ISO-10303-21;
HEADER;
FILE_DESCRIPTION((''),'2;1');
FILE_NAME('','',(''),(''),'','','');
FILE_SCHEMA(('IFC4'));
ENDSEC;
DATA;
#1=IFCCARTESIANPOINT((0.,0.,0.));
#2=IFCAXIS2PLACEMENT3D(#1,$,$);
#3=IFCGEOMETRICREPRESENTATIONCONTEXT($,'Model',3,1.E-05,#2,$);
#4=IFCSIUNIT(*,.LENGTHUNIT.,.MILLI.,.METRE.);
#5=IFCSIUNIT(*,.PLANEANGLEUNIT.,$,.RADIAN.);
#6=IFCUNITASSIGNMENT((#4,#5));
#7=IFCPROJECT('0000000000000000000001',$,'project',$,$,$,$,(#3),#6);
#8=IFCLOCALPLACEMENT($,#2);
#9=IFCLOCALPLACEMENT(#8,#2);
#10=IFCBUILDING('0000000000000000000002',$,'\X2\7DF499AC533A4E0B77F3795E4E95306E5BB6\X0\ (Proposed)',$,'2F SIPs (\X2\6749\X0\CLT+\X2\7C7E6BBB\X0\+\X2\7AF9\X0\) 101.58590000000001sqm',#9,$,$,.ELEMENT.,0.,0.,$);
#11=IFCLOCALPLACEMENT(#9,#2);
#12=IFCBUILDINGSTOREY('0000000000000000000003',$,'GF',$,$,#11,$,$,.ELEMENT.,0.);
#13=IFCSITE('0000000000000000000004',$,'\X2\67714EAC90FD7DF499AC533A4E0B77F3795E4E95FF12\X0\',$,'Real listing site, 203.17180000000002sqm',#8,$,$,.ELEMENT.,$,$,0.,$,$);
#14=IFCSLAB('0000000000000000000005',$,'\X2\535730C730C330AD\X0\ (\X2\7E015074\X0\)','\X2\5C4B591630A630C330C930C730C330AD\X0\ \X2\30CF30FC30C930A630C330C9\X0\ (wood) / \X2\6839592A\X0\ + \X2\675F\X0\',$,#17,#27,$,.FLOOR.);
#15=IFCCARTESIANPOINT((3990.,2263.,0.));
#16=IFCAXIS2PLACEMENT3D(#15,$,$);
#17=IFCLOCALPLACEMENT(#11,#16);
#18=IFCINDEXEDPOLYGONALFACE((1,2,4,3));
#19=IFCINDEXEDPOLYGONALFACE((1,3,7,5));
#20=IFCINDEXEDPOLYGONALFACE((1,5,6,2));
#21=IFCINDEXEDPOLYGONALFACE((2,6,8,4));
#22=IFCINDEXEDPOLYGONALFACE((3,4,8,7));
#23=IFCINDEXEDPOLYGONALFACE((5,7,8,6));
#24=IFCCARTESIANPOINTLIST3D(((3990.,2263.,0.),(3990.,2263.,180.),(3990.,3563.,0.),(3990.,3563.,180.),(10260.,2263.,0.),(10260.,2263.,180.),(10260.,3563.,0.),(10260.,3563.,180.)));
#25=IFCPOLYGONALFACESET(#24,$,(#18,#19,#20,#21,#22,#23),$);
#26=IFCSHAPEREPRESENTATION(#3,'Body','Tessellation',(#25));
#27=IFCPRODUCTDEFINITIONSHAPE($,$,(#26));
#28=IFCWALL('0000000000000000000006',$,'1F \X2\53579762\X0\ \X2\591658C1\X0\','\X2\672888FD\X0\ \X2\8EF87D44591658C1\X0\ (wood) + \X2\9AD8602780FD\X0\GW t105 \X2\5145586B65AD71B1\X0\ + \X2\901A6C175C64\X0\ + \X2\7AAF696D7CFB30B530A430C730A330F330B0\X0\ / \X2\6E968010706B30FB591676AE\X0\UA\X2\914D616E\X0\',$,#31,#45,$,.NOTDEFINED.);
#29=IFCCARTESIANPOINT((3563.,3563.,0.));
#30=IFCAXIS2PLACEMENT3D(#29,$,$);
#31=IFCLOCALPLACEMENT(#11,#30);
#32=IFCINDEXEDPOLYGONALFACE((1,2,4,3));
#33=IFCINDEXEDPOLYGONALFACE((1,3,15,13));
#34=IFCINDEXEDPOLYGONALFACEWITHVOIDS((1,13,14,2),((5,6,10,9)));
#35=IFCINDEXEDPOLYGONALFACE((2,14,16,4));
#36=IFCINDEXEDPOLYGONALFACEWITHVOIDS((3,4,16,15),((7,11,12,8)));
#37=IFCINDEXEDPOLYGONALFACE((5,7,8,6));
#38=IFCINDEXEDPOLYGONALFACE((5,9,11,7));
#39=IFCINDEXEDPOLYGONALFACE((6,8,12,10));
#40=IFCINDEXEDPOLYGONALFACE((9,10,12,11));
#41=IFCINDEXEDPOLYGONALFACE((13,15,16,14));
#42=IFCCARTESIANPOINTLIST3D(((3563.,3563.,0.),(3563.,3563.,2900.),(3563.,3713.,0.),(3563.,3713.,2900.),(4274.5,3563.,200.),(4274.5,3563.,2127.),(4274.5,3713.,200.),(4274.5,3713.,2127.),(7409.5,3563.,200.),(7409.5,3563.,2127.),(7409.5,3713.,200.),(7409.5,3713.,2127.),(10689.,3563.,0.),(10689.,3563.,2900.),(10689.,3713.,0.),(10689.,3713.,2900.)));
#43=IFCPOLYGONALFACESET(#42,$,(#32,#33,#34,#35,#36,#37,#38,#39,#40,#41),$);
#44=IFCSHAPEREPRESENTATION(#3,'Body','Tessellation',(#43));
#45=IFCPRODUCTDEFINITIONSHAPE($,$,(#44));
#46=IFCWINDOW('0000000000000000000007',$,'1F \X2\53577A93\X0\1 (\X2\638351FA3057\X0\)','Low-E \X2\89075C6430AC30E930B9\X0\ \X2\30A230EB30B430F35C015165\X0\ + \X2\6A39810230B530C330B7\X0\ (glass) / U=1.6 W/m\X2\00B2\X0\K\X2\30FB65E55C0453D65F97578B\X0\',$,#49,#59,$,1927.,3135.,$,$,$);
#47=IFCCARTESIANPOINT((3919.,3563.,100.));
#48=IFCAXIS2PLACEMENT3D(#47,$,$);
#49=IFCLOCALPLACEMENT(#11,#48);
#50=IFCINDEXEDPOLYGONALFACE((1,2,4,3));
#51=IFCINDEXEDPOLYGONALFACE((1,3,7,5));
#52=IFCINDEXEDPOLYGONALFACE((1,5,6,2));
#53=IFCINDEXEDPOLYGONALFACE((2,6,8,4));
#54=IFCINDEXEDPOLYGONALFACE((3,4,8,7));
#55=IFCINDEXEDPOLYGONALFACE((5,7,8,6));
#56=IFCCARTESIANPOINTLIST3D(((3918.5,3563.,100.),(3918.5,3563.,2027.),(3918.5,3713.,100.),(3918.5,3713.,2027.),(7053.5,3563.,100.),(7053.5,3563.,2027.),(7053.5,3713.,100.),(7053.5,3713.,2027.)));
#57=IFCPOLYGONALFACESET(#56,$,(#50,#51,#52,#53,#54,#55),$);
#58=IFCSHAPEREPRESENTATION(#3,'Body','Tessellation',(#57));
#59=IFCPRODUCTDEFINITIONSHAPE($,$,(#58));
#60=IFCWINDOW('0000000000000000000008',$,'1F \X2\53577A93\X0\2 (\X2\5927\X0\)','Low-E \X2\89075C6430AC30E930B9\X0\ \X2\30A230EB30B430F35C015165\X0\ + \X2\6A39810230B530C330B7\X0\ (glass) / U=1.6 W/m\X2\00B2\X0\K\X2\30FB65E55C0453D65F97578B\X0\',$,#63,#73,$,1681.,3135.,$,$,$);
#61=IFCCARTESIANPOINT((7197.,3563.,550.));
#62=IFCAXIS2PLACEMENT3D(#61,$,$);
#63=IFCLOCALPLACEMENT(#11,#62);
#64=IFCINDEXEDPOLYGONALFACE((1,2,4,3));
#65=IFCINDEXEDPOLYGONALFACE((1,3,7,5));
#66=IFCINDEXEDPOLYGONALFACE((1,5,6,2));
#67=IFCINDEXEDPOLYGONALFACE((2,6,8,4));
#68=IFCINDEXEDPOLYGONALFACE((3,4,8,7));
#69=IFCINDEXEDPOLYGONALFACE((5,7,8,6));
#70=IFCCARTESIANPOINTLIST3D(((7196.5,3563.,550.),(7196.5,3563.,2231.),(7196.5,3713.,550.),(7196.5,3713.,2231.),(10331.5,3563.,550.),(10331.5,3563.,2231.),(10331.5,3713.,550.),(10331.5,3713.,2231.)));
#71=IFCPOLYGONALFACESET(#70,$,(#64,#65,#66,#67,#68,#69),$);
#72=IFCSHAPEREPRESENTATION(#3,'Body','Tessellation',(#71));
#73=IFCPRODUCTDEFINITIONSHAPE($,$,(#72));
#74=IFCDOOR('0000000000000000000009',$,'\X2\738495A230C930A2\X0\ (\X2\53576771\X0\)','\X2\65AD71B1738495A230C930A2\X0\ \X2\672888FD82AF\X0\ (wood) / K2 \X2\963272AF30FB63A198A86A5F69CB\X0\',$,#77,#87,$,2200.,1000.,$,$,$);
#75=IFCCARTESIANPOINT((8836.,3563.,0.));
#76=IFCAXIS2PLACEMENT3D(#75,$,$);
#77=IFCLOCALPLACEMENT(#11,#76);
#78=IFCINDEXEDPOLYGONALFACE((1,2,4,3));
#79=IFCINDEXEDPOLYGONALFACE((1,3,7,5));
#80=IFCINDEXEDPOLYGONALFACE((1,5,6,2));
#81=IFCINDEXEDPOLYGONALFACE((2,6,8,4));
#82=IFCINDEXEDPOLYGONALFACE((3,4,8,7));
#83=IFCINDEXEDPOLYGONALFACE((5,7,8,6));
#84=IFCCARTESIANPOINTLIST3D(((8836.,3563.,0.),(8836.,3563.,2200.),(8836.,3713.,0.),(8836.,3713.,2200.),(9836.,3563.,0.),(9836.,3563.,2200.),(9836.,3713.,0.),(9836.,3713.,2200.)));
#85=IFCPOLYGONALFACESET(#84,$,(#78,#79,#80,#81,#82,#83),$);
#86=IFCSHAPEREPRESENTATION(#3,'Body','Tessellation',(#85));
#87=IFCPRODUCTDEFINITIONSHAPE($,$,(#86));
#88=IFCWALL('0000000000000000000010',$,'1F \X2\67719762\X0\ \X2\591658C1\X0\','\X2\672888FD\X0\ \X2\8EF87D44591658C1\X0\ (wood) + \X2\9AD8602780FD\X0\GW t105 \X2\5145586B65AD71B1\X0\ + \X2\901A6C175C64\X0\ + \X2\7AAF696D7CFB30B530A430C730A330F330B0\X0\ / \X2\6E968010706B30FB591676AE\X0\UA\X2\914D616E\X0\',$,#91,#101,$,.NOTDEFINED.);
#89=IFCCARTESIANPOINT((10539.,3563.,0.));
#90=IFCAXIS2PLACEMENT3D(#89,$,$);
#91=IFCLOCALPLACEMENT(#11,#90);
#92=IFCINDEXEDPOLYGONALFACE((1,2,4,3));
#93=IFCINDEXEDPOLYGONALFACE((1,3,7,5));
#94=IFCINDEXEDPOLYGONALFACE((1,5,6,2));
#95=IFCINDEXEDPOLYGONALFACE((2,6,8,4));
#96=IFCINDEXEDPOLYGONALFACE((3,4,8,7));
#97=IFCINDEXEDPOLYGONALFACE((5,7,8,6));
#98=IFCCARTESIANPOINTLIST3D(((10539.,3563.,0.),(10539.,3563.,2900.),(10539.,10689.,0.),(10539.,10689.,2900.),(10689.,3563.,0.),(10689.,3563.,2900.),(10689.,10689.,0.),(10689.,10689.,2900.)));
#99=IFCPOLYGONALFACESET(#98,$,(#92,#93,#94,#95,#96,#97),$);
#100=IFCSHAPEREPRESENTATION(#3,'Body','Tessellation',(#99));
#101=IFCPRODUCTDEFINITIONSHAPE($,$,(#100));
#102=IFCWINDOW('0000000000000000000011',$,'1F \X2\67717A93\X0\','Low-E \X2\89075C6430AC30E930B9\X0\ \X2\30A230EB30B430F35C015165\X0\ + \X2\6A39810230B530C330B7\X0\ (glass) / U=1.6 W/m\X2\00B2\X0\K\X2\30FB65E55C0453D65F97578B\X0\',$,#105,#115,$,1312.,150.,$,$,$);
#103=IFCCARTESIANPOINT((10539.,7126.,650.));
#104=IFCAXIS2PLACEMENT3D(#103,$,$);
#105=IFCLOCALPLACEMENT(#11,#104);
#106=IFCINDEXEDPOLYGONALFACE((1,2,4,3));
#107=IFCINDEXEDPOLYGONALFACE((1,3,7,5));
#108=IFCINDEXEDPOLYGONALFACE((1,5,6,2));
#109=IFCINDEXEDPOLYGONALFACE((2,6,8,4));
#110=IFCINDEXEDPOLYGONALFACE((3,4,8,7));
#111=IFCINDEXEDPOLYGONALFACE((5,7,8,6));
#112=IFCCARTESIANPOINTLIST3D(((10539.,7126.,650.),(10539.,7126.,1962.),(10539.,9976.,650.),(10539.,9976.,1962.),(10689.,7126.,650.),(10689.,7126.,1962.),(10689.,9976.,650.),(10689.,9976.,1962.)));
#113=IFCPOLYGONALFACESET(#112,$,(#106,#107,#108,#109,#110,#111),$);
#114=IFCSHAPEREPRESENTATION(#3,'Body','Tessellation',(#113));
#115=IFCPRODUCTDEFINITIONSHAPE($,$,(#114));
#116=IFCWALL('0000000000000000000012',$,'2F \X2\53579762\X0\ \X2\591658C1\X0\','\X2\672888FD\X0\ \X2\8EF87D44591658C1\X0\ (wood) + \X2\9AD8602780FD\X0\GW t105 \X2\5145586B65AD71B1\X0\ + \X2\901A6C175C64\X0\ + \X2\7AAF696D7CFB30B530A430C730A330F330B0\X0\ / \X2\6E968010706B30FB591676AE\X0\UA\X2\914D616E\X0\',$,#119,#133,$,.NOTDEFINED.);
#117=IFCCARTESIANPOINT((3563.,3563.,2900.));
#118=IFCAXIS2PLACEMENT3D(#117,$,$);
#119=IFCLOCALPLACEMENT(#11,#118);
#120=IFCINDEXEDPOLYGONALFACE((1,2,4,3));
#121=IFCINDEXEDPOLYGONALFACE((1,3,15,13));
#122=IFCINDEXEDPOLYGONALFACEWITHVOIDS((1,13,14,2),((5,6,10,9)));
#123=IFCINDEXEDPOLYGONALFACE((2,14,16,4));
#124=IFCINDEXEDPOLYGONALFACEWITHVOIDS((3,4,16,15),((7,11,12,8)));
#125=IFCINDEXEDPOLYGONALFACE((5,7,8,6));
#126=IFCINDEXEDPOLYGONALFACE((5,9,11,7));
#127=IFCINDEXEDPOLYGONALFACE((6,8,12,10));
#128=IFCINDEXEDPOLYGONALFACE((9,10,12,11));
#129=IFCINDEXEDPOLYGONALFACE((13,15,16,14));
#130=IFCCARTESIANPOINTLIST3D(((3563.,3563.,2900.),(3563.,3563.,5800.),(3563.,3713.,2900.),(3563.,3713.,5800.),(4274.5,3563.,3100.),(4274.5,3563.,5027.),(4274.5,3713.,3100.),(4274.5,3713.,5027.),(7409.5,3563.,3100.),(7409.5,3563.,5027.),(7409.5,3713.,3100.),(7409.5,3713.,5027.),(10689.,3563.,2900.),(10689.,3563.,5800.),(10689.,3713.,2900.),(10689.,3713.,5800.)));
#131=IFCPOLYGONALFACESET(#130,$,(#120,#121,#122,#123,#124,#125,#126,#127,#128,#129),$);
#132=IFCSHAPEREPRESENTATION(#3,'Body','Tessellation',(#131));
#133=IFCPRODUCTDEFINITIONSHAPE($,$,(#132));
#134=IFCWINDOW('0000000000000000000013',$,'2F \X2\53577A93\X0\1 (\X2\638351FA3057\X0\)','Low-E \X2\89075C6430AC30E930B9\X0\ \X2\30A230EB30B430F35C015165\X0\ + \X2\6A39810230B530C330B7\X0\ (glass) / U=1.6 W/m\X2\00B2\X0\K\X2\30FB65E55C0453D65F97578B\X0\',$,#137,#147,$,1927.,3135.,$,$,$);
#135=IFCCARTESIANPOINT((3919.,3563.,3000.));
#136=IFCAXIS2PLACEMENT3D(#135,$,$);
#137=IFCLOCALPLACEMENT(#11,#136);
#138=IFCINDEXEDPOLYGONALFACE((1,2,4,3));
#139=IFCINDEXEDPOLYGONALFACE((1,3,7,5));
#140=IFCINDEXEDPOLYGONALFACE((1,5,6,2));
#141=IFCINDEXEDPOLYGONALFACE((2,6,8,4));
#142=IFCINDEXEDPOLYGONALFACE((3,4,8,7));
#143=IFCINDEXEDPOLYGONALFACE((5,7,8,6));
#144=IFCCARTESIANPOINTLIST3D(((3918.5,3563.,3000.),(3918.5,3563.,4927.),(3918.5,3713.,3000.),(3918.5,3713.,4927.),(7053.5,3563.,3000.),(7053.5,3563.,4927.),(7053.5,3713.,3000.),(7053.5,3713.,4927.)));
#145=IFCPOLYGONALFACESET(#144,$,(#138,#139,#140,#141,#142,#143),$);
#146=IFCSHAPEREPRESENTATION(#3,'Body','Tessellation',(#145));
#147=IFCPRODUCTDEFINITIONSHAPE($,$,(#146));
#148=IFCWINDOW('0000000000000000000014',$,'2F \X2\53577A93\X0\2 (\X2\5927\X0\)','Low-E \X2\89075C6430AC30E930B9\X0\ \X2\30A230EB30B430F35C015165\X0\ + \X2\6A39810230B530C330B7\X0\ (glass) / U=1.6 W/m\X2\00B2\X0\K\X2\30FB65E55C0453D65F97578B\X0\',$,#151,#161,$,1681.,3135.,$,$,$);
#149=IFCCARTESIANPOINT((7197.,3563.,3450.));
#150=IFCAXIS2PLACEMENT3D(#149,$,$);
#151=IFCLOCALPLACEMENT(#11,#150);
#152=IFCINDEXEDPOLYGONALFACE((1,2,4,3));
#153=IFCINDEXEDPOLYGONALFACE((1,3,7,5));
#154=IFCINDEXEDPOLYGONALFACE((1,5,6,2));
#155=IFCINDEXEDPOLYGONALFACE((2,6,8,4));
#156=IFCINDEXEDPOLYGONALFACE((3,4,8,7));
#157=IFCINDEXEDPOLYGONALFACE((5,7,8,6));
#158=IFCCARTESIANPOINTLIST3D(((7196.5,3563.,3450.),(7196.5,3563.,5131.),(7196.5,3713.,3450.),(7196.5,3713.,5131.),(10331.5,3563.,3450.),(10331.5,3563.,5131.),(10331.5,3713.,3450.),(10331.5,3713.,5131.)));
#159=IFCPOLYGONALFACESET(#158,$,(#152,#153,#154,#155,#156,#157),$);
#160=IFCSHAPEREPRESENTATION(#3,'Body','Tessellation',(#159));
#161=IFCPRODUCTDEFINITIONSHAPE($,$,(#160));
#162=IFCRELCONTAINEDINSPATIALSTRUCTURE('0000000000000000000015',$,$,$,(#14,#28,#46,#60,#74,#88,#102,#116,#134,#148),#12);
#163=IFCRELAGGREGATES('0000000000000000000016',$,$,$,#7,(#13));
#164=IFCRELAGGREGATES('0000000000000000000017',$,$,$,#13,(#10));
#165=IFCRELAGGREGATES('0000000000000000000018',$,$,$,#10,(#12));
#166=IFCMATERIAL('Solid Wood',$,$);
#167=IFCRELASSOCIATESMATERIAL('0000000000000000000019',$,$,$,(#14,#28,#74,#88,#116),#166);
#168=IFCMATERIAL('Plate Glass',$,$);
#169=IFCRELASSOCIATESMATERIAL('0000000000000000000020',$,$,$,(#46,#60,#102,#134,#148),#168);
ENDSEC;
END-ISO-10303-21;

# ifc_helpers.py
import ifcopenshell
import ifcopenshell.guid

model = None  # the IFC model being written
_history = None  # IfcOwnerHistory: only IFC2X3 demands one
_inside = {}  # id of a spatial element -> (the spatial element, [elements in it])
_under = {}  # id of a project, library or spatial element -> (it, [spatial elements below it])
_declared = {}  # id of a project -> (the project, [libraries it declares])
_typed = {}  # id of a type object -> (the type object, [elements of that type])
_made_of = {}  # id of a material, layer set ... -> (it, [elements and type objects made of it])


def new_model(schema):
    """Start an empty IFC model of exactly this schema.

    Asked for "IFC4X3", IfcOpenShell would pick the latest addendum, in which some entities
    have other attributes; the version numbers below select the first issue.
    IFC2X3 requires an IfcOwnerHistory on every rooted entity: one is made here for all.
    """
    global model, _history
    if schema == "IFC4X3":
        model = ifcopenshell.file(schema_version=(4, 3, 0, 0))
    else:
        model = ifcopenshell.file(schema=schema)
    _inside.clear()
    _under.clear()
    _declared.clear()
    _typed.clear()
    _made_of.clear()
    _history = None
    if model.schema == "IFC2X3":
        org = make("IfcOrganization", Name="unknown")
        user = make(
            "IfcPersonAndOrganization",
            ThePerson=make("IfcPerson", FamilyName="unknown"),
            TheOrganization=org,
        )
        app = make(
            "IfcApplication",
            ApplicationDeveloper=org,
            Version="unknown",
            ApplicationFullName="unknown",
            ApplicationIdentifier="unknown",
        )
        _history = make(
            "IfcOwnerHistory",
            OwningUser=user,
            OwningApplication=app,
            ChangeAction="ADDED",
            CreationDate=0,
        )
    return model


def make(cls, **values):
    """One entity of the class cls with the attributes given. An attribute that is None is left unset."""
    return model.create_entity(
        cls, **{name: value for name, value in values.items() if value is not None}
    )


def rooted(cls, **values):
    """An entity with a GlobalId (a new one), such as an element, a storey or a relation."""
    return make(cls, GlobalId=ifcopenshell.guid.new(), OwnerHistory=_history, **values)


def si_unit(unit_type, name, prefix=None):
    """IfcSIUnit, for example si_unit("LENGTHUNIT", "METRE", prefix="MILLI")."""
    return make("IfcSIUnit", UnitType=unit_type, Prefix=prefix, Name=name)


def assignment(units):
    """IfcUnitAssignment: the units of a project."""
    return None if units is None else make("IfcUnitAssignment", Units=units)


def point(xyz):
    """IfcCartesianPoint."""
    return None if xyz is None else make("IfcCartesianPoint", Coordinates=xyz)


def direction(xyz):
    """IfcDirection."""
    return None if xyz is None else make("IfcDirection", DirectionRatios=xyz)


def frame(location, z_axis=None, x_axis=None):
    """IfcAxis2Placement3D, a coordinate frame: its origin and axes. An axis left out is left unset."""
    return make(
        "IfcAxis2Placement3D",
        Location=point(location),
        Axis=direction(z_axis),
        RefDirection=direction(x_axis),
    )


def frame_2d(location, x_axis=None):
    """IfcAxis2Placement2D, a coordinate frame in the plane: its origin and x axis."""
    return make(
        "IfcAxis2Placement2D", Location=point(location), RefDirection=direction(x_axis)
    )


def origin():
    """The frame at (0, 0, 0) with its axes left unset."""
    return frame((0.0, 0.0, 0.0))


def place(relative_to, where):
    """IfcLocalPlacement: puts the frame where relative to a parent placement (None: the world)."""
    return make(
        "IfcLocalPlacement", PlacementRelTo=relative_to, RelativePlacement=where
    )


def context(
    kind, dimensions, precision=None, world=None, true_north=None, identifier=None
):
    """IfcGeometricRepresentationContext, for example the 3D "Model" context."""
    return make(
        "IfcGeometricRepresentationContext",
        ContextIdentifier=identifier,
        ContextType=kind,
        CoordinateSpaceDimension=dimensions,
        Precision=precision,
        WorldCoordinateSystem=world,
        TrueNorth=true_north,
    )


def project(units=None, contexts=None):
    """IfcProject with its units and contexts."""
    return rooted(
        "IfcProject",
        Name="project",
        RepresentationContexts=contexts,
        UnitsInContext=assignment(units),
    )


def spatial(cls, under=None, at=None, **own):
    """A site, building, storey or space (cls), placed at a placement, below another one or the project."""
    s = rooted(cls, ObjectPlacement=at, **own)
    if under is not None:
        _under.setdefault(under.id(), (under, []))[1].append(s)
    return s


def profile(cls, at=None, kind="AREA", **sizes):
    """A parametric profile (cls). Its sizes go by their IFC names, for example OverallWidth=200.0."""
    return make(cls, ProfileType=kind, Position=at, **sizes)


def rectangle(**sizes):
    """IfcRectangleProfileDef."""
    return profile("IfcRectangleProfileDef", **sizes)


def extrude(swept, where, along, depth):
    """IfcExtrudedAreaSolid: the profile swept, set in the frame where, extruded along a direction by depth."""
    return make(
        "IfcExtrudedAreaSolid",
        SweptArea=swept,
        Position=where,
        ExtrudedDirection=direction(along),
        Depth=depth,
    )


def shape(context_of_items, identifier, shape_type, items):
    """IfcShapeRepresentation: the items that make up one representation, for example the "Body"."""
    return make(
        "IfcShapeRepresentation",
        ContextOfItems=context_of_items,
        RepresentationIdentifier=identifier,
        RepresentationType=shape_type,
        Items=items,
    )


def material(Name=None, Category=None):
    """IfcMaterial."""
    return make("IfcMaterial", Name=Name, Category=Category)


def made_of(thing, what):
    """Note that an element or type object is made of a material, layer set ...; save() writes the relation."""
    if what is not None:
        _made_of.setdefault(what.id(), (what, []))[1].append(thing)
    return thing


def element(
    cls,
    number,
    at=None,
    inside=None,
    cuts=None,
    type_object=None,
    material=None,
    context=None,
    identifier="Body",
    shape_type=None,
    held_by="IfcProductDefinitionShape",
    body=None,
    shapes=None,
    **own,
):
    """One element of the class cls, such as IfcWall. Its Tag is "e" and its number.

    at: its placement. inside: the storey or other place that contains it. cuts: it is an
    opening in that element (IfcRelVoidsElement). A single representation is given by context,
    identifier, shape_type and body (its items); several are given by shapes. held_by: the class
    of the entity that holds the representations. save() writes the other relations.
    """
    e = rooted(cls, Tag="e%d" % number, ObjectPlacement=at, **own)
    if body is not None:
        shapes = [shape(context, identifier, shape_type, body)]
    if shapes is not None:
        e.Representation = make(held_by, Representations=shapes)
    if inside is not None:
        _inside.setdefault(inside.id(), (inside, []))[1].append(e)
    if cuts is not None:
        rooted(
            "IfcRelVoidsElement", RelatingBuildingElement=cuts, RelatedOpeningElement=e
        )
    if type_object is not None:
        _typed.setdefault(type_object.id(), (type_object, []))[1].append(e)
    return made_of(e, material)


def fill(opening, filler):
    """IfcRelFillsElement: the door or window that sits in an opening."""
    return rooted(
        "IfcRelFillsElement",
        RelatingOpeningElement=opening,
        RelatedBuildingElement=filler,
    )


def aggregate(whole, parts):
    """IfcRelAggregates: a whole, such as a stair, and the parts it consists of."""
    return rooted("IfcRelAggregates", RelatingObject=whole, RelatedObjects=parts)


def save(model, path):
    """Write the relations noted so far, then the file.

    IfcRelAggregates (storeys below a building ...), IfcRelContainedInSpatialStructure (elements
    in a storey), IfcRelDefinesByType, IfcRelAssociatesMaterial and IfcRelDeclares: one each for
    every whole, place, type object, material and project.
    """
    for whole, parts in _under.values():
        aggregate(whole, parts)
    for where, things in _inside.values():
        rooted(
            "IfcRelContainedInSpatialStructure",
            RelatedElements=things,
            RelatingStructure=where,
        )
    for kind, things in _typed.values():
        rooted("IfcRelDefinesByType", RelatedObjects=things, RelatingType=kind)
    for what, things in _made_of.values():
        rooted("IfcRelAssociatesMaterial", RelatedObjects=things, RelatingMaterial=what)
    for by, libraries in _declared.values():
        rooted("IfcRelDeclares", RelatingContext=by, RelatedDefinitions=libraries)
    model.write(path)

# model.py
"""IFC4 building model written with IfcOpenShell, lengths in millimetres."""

from ifc_helpers import new_model, si_unit, frame, frame_2d, origin, place, context, project, spatial, rectangle, extrude, material, element, fill, save


model = new_model("IFC4")

# Units and contexts
model_context = context("Model", 3, precision=1e-05, world=origin())
ifc_project = project(units=[si_unit("LENGTHUNIT", "METRE", prefix="MILLI"), si_unit("PLANEANGLEUNIT", "RADIAN")], contexts=[model_context])

# Site, building, storey
site_placement = place(None, origin())
site = spatial("IfcSite", under=ifc_project, at=site_placement, Name="東京都練馬区下石神井２", ObjectType="Real listing site, 203.17180000000002sqm", CompositionType="ELEMENT", RefElevation=0.0)
building_placement = place(site_placement, origin())
building = spatial("IfcBuilding", under=site, at=building_placement, Name="練馬区下石神井の家 (Proposed)", ObjectType="2F SIPs (杉CLT+籾殻+竹) 101.58590000000001sqm", CompositionType="ELEMENT", ElevationOfRefHeight=0.0, ElevationOfTerrain=0.0)
storey_placement = place(building_placement, origin())
storey = spatial("IfcBuildingStorey", under=building, at=storey_placement, Name="GF", CompositionType="ELEMENT", Elevation=0.0)

# Slab
ifc_material_1 = material(Name="Solid Wood")
slab_1_placement = place(storey_placement, frame((3990.0, 2263.0, 0.0)))
element("IfcSlab", 1, at=slab_1_placement, inside=storey, material=ifc_material_1, Name="南デッキ (縁側)", Description="屋外ウッドデッキ ハードウッド (wood) / 根太 + 束", PredefinedType="FLOOR", context=model_context, shape_type="SweptSolid", body=[
    extrude(rectangle(XDim=6270.0, YDim=1300.0, at=frame_2d((3135.0, 650.0))), frame((3990.0, 2263.0, 0.0)), (0.0, 0.0, 1.0), 180.0),
])

# Wall, openings, windows, door
wall_1_placement = place(storey_placement, frame((3563.0, 3563.0, 0.0)))
wall_1 = element("IfcWall", 2, at=wall_1_placement, inside=storey, material=ifc_material_1, Name="1F 南面 外壁", Description="木製 軸組外壁 (wood) + 高性能GW t105 充填断熱 + 通気層 + 窯業系サイディング / 準耐火・外皮UA配慮", PredefinedType="NOTDEFINED", context=model_context, shape_type="SweptSolid", body=[
    extrude(rectangle(XDim=7126.0, YDim=150.0, at=frame_2d((3563.0, 75.0))), frame((3563.0, 3563.0, 0.0)), (0.0, 0.0, 1.0), 2900.0),
])
opening_1_placement = place(storey_placement, frame((3919.0, 3563.0, 100.0)))
opening_1 = element("IfcOpeningElement", 3, at=opening_1_placement, cuts=wall_1, PredefinedType="NOTDEFINED", context=model_context, shape_type="SweptSolid", body=[
    extrude(rectangle(XDim=3135.0, YDim=150.0, at=frame_2d((1567.0, 75.0))), frame((3919.0, 3563.0, 100.0)), (0.0, 0.0, 1.0), 1927.0),
])
opening_2_placement = place(storey_placement, frame((7197.0, 3563.0, 550.0)))
opening_2 = element("IfcOpeningElement", 4, at=opening_2_placement, cuts=wall_1, PredefinedType="NOTDEFINED", context=model_context, shape_type="SweptSolid", body=[
    extrude(rectangle(XDim=3135.0, YDim=150.0, at=frame_2d((1567.0, 75.0))), frame((7197.0, 3563.0, 550.0)), (0.0, 0.0, 1.0), 1681.0),
])
opening_3_placement = place(storey_placement, frame((8836.0, 3563.0, 0.0)))
opening_3 = element("IfcOpeningElement", 5, at=opening_3_placement, cuts=wall_1, PredefinedType="NOTDEFINED", context=model_context, shape_type="SweptSolid", body=[
    extrude(rectangle(XDim=1000.0, YDim=150.0, at=frame_2d((500.0, 75.0))), frame((8836.0, 3563.0, 0.0)), (0.0, 0.0, 1.0), 2200.0),
])
ifc_material_2 = material(Name="Plate Glass")
window_1_placement = place(storey_placement, frame((3919.0, 3563.0, 100.0)))
window_1 = element("IfcWindow", 6, at=window_1_placement, inside=storey, material=ifc_material_2, Name="1F 南窓1 (掃出し)", Description="Low-E 複層ガラス アルゴン封入 + 樹脂サッシ (glass) / U=1.6 W/m²K・日射取得型", OverallHeight=1927.0, OverallWidth=3135.0, context=model_context, shape_type="SweptSolid", body=[
    extrude(rectangle(XDim=3135.0, YDim=150.0, at=frame_2d((1567.0, 75.0))), frame((3919.0, 3563.0, 100.0)), (0.0, 0.0, 1.0), 1927.0),
])
fill(opening_1, window_1)
window_2_placement = place(storey_placement, frame((7197.0, 3563.0, 550.0)))
window_2 = element("IfcWindow", 7, at=window_2_placement, inside=storey, material=ifc_material_2, Name="1F 南窓2 (大)", Description="Low-E 複層ガラス アルゴン封入 + 樹脂サッシ (glass) / U=1.6 W/m²K・日射取得型", OverallHeight=1681.0, OverallWidth=3135.0, context=model_context, shape_type="SweptSolid", body=[
    extrude(rectangle(XDim=3135.0, YDim=150.0, at=frame_2d((1567.0, 75.0))), frame((7197.0, 3563.0, 550.0)), (0.0, 0.0, 1.0), 1681.0),
])
fill(opening_2, window_2)
door_placement = place(storey_placement, frame((8836.0, 3563.0, 0.0)))
door = element("IfcDoor", 8, at=door_placement, inside=storey, material=ifc_material_1, Name="玄関ドア (南東)", Description="断熱玄関ドア 木製芯 (wood) / K2 防犯・採風機構", OverallHeight=2200.0, OverallWidth=1000.0, context=model_context, shape_type="SweptSolid", body=[
    extrude(rectangle(XDim=1000.0, YDim=150.0, at=frame_2d((500.0, 75.0))), frame((8836.0, 3563.0, 0.0)), (0.0, 0.0, 1.0), 2200.0),
])
fill(opening_3, door)

# Wall, opening, window
wall_2_placement = place(storey_placement, frame((10539.0, 3563.0, 0.0)))
wall_2 = element("IfcWall", 9, at=wall_2_placement, inside=storey, material=ifc_material_1, Name="1F 東面 外壁", Description="木製 軸組外壁 (wood) + 高性能GW t105 充填断熱 + 通気層 + 窯業系サイディング / 準耐火・外皮UA配慮", PredefinedType="NOTDEFINED", context=model_context, shape_type="SweptSolid", body=[
    extrude(rectangle(XDim=150.0, YDim=7126.0, at=frame_2d((75.0, 3563.0))), frame((10539.0, 3563.0, 0.0)), (0.0, 0.0, 1.0), 2900.0),
])
opening_4_placement = place(storey_placement, frame((10539.0, 7126.0, 650.0)))
opening_4 = element("IfcOpeningElement", 10, at=opening_4_placement, cuts=wall_2, PredefinedType="NOTDEFINED", context=model_context, shape_type="SweptSolid", body=[
    extrude(rectangle(XDim=150.0, YDim=2850.0, at=frame_2d((75.0, 1425.0))), frame((10539.0, 7126.0, 650.0)), (0.0, 0.0, 1.0), 1312.0),
])
window_3_placement = place(storey_placement, frame((10539.0, 7126.0, 650.0)))
window_3 = element("IfcWindow", 11, at=window_3_placement, inside=storey, material=ifc_material_2, Name="1F 東窓", Description="Low-E 複層ガラス アルゴン封入 + 樹脂サッシ (glass) / U=1.6 W/m²K・日射取得型", OverallHeight=1312.0, OverallWidth=150.0, context=model_context, shape_type="SweptSolid", body=[
    extrude(rectangle(XDim=150.0, YDim=2850.0, at=frame_2d((75.0, 1425.0))), frame((10539.0, 7126.0, 650.0)), (0.0, 0.0, 1.0), 1312.0),
])
fill(opening_4, window_3)

# Wall, openings, windows
wall_3_placement = place(storey_placement, frame((3563.0, 3563.0, 2900.0)))
wall_3 = element("IfcWall", 12, at=wall_3_placement, inside=storey, material=ifc_material_1, Name="2F 南面 外壁", Description="木製 軸組外壁 (wood) + 高性能GW t105 充填断熱 + 通気層 + 窯業系サイディング / 準耐火・外皮UA配慮", PredefinedType="NOTDEFINED", context=model_context, shape_type="SweptSolid", body=[
    extrude(rectangle(XDim=7126.0, YDim=150.0, at=frame_2d((3563.0, 75.0))), frame((3563.0, 3563.0, 2900.0)), (0.0, 0.0, 1.0), 2900.0),
])
opening_5_placement = place(storey_placement, frame((3919.0, 3563.0, 3000.0)))
opening_5 = element("IfcOpeningElement", 13, at=opening_5_placement, cuts=wall_3, PredefinedType="NOTDEFINED", context=model_context, shape_type="SweptSolid", body=[
    extrude(rectangle(XDim=3135.0, YDim=150.0, at=frame_2d((1567.0, 75.0))), frame((3919.0, 3563.0, 3000.0)), (0.0, 0.0, 1.0), 1927.0),
])
opening_6_placement = place(storey_placement, frame((7197.0, 3563.0, 3450.0)))
opening_6 = element("IfcOpeningElement", 14, at=opening_6_placement, cuts=wall_3, PredefinedType="NOTDEFINED", context=model_context, shape_type="SweptSolid", body=[
    extrude(rectangle(XDim=3135.0, YDim=150.0, at=frame_2d((1567.0, 75.0))), frame((7197.0, 3563.0, 3450.0)), (0.0, 0.0, 1.0), 1681.0),
])
window_4_placement = place(storey_placement, frame((3919.0, 3563.0, 3000.0)))
window_4 = element("IfcWindow", 15, at=window_4_placement, inside=storey, material=ifc_material_2, Name="2F 南窓1 (掃出し)", Description="Low-E 複層ガラス アルゴン封入 + 樹脂サッシ (glass) / U=1.6 W/m²K・日射取得型", OverallHeight=1927.0, OverallWidth=3135.0, context=model_context, shape_type="SweptSolid", body=[
    extrude(rectangle(XDim=3135.0, YDim=150.0, at=frame_2d((1567.0, 75.0))), frame((3919.0, 3563.0, 3000.0)), (0.0, 0.0, 1.0), 1927.0),
])
fill(opening_5, window_4)
window_5_placement = place(storey_placement, frame((7197.0, 3563.0, 3450.0)))
window_5 = element("IfcWindow", 16, at=window_5_placement, inside=storey, material=ifc_material_2, Name="2F 南窓2 (大)", Description="Low-E 複層ガラス アルゴン封入 + 樹脂サッシ (glass) / U=1.6 W/m²K・日射取得型", OverallHeight=1681.0, OverallWidth=3135.0, context=model_context, shape_type="SweptSolid", body=[
    extrude(rectangle(XDim=3135.0, YDim=150.0, at=frame_2d((1567.0, 75.0))), frame((7197.0, 3563.0, 3450.0)), (0.0, 0.0, 1.0), 1681.0),
])
fill(opening_6, window_5)

save(model, "model.ifc")
